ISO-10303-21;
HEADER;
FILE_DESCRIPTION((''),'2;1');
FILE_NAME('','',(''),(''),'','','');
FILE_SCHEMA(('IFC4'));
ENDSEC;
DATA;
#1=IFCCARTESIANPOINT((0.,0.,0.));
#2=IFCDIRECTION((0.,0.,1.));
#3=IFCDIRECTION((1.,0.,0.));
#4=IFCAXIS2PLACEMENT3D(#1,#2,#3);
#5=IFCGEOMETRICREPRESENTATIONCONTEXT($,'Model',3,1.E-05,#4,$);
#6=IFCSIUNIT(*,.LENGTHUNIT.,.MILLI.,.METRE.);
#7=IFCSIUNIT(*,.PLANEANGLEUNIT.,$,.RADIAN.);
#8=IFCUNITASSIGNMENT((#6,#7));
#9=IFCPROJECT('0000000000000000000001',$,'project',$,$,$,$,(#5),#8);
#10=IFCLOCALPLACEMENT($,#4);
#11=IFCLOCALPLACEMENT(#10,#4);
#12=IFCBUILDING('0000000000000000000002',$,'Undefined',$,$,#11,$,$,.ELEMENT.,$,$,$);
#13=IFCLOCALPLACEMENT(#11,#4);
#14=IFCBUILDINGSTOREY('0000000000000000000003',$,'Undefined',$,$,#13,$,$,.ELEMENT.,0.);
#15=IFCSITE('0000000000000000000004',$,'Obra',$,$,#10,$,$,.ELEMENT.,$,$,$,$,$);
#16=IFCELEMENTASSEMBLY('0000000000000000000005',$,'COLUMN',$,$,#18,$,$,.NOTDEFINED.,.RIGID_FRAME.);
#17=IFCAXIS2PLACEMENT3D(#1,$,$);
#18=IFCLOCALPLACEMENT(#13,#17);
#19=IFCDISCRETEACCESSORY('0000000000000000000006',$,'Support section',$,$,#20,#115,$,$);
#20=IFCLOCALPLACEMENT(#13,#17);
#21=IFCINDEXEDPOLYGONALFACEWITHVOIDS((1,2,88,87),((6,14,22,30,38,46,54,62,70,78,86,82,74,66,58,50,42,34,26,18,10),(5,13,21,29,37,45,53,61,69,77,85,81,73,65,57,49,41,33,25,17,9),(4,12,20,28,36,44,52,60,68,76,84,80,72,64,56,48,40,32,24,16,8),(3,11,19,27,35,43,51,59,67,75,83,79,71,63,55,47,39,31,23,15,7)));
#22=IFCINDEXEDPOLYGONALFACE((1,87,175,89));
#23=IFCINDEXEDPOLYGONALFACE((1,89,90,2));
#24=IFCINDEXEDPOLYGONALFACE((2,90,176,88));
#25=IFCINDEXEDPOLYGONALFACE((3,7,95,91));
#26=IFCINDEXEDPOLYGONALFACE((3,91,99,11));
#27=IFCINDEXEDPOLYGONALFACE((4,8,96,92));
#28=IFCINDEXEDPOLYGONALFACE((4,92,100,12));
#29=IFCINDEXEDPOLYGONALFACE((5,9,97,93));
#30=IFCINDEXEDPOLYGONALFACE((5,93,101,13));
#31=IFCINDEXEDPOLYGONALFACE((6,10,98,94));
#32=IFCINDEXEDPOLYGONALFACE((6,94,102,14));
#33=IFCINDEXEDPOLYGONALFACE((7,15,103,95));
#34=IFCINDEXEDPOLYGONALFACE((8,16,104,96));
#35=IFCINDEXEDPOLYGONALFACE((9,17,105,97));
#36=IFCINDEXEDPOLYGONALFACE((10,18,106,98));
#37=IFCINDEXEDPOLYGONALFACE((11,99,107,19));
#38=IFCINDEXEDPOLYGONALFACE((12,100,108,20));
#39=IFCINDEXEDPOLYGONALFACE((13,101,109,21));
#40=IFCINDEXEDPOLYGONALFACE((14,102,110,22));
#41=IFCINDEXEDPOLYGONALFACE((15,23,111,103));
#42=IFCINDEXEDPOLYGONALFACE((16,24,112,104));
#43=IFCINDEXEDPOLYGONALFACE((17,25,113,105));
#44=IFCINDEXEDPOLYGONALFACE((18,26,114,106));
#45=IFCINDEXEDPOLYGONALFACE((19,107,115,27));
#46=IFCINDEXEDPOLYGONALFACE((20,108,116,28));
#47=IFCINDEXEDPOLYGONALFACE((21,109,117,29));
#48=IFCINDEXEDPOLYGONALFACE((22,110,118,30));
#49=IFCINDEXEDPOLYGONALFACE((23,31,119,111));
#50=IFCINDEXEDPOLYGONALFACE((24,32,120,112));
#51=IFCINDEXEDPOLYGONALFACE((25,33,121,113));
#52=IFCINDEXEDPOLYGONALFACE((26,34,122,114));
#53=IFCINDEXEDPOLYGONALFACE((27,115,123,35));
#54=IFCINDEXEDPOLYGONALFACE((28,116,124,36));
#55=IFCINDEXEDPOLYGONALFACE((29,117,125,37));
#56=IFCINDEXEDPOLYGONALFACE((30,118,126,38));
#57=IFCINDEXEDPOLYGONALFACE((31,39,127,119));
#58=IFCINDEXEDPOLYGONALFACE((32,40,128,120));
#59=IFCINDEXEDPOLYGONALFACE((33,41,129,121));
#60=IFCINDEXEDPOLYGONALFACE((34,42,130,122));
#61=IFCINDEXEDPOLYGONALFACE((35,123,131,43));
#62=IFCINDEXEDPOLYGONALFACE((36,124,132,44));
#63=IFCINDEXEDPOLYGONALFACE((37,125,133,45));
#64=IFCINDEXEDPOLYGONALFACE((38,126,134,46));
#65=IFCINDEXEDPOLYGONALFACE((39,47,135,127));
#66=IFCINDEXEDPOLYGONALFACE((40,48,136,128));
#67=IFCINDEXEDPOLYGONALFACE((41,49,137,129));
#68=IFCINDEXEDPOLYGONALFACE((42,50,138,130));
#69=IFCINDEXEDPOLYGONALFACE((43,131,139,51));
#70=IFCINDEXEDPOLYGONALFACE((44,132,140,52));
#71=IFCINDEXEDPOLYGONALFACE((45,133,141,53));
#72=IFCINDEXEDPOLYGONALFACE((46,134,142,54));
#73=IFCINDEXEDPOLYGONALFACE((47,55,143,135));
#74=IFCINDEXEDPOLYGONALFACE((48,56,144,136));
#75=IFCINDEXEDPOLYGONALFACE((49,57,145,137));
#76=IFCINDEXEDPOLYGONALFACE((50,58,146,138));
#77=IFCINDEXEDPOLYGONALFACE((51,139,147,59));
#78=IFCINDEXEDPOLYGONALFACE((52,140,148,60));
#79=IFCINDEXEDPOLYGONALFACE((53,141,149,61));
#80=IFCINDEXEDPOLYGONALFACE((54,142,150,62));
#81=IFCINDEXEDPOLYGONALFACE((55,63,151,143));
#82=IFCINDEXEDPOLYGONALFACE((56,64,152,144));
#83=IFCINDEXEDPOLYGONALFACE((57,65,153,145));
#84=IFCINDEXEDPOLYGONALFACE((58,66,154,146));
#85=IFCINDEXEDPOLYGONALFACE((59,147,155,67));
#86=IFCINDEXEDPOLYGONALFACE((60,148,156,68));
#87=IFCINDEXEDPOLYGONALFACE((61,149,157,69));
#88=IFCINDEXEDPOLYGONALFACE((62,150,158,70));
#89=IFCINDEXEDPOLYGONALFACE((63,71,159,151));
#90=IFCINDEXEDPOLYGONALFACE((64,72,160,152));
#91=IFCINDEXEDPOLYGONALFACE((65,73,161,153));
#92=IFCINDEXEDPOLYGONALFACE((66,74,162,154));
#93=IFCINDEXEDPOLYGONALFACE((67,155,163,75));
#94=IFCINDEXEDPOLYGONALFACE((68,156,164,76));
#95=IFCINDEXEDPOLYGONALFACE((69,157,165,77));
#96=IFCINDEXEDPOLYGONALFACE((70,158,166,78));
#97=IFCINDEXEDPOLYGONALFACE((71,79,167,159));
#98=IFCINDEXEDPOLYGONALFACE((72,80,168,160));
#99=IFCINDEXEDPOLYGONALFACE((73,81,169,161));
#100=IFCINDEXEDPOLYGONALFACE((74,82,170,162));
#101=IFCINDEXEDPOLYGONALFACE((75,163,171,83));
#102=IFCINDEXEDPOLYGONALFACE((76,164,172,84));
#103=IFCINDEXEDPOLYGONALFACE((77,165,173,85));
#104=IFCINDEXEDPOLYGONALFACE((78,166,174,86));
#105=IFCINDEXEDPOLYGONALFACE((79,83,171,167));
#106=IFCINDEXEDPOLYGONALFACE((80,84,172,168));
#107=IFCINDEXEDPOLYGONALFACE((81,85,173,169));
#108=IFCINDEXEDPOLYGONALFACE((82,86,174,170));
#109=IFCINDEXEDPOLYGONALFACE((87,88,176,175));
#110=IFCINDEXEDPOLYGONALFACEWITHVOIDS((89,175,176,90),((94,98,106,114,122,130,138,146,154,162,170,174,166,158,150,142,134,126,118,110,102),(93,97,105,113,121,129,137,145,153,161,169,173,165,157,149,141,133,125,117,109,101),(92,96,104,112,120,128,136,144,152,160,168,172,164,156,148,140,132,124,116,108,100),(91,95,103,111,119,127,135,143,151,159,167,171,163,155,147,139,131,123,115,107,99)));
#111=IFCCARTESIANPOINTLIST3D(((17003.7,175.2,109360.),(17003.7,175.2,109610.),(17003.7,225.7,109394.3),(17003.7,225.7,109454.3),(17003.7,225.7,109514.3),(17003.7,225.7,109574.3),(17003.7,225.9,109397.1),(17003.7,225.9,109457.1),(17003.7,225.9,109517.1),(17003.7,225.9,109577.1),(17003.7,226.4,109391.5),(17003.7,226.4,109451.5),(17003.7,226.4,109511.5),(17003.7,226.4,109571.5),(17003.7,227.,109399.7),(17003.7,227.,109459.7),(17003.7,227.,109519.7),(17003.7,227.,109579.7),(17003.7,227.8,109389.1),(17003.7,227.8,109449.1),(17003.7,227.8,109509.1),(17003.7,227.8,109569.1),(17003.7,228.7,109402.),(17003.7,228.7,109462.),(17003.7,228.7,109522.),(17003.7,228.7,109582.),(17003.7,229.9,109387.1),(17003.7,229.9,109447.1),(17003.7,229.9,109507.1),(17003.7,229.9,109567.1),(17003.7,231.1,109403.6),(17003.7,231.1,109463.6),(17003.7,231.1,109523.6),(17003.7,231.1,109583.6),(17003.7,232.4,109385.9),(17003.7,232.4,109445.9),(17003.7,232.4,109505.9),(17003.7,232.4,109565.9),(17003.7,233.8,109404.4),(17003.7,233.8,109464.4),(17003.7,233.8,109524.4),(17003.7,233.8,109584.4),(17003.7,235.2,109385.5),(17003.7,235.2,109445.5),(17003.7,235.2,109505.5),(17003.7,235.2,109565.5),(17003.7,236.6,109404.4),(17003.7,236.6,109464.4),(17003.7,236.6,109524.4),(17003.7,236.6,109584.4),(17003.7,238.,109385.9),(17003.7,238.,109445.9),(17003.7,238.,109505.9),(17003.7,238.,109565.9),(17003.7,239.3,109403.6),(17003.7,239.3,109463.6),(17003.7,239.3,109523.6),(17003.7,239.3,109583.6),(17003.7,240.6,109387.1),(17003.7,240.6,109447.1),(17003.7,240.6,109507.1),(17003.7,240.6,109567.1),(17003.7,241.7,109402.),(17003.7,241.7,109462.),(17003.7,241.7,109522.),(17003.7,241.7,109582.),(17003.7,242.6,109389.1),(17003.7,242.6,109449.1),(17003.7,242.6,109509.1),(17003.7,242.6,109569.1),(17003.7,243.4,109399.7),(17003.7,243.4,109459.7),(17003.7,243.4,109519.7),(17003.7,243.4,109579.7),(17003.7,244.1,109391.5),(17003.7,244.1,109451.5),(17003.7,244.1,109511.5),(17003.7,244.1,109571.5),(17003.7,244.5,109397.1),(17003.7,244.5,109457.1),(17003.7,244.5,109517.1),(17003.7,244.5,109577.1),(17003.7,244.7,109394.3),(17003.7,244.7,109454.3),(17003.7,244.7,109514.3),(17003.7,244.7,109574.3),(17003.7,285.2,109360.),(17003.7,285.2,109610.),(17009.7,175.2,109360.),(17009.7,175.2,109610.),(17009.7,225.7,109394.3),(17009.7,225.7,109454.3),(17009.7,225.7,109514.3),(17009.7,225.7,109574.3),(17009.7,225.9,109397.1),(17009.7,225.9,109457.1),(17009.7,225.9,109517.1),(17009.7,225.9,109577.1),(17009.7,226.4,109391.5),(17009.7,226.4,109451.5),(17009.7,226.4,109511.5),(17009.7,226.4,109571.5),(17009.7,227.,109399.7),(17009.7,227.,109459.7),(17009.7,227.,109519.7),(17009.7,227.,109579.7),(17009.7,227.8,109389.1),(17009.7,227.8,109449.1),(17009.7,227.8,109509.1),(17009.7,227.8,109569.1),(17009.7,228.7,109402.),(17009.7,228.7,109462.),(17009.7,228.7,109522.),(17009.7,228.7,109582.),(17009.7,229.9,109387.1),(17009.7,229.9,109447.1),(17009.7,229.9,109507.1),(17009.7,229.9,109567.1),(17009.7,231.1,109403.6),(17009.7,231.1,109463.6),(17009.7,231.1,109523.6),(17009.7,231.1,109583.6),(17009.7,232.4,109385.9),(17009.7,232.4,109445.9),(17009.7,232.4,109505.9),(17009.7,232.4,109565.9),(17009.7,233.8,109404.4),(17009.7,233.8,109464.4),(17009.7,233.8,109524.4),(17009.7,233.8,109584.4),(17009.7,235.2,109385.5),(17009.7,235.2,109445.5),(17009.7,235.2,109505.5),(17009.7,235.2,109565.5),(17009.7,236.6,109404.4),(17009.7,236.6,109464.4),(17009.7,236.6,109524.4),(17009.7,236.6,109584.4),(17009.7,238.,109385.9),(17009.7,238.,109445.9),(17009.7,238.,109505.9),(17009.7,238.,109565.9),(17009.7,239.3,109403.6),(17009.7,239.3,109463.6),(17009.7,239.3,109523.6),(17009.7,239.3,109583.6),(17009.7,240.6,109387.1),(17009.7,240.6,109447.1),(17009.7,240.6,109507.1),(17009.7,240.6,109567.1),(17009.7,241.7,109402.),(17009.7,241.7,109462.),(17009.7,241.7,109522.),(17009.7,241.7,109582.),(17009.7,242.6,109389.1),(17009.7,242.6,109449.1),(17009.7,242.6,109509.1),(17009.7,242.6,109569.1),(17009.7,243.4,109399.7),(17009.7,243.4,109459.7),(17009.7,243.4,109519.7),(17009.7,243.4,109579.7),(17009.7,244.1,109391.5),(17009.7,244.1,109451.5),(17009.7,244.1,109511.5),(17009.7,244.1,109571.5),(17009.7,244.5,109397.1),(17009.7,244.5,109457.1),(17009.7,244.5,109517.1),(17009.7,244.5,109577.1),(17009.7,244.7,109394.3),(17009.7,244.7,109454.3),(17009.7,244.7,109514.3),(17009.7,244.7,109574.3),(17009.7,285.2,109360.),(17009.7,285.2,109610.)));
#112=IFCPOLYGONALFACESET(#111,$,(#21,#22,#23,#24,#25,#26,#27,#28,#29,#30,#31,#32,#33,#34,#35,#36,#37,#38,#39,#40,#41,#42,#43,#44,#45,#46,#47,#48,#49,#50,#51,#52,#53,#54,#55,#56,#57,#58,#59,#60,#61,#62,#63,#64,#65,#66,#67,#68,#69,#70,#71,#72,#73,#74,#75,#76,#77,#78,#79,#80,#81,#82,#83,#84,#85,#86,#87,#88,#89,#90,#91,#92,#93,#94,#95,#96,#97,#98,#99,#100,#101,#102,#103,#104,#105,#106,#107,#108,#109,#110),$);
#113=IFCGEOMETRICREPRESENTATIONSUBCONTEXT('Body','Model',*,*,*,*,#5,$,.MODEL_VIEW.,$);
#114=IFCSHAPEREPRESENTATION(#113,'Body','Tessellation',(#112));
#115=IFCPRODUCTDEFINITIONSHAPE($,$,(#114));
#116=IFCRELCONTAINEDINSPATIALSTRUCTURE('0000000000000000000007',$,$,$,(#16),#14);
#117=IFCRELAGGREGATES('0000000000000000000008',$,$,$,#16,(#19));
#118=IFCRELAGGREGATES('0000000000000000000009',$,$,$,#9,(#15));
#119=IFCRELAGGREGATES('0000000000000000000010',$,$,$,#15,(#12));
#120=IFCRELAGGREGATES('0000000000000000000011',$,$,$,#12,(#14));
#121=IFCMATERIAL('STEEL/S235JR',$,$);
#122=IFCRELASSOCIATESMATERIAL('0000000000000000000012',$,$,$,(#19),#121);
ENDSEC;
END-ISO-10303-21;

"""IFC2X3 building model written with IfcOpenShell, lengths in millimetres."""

from ifc_helpers import new_model, si_unit, frame, origin_with_axes, origin_2d_with_axis, place, context, subcontext, project, spatial, rectangle, circle, extrude, source, transform, mapped, material, element, aggregate, save


model = new_model("IFC2X3")

# Units and contexts
model_context = context("Model", 3, precision=1e-05, world=origin_with_axes())
body_context = subcontext(model_context, "Body", "Model", "MODEL_VIEW")
ifc_project = project(units=[si_unit("LENGTHUNIT", "METRE", prefix="MILLI"), si_unit("PLANEANGLEUNIT", "RADIAN")], contexts=[model_context])

# Site, building, storey
site_placement = place(None, origin_with_axes())
site = spatial("IfcSite", under=ifc_project, at=site_placement, Name="Obra", CompositionType="ELEMENT")
building_placement = place(site_placement, origin_with_axes())
building = spatial("IfcBuilding", under=site, at=building_placement, Name="Undefined", CompositionType="ELEMENT")
storey_placement = place(building_placement, origin_with_axes())
storey = spatial("IfcBuildingStorey", under=building, at=storey_placement, Name="Undefined", CompositionType="ELEMENT", Elevation=0.0)

# Shared definitions
ifc_material_1 = material(Name="STEEL/S235JR")

# Element assembly, discrete accessory, opening
assembly_1_placement = place(storey_placement, origin_with_axes())
assembly_1 = element("IfcElementAssembly", 1, at=assembly_1_placement, inside=storey, Name="COLUMN", AssemblyPlace="NOTDEFINED", PredefinedType="RIGID_FRAME")
discrete_accessory_1_placement = place(assembly_1_placement, frame((17006.7, 230.2, 109360.0), z_axis=(0.0, 0.0, 1.0), x_axis=(0.0, -1.0, 0.0)))
discrete_accessory_1 = element("IfcDiscreteAccessory", 2, at=discrete_accessory_1_placement, material=ifc_material_1, Name="Support section", context=body_context, shape_type="SweptSolid", body=[
    extrude(rectangle(XDim=6.0, YDim=110.0, at=origin_2d_with_axis()), frame((0.0, 0.0, 250.0), z_axis=(0.0, 0.0, -1.0), x_axis=(0.0, 1.0, 0.0)), (0.0, 0.0, 1.0), 250.0),
])
shared_shape_1 = source(origin_with_axes(), body_context, "Body", "SweptSolid", [
    extrude(circle(Radius=9.5, at=origin_2d_with_axis()), frame((0.0, -9.9, 0.0), z_axis=(0.0, 1.0, 0.0), x_axis=(1.0, 0.0, 0.0)), (0.0, 0.0, 1.0), 6.2),
])
opening_1_placement = place(assembly_1_placement, frame((17000.0, 185.2, 109650.0), z_axis=(0.0, 1.0, 0.0), x_axis=(0.0, 0.0, -1.0)))
element("IfcOpeningElement", 3, at=opening_1_placement, cuts=discrete_accessory_1, ObjectType="Opening", context=body_context, shape_type="MappedRepresentation", body=[
    mapped(shared_shape_1, transform((75.0, 0.0, 50.0))),
    mapped(shared_shape_1, transform((135.0, 0.0, 50.0))),
    mapped(shared_shape_1, transform((195.0, 0.0, 50.0))),
    mapped(shared_shape_1, transform((255.0, 0.0, 50.0))),
])
aggregate(assembly_1, [discrete_accessory_1])

save(model, "model.ifc")
